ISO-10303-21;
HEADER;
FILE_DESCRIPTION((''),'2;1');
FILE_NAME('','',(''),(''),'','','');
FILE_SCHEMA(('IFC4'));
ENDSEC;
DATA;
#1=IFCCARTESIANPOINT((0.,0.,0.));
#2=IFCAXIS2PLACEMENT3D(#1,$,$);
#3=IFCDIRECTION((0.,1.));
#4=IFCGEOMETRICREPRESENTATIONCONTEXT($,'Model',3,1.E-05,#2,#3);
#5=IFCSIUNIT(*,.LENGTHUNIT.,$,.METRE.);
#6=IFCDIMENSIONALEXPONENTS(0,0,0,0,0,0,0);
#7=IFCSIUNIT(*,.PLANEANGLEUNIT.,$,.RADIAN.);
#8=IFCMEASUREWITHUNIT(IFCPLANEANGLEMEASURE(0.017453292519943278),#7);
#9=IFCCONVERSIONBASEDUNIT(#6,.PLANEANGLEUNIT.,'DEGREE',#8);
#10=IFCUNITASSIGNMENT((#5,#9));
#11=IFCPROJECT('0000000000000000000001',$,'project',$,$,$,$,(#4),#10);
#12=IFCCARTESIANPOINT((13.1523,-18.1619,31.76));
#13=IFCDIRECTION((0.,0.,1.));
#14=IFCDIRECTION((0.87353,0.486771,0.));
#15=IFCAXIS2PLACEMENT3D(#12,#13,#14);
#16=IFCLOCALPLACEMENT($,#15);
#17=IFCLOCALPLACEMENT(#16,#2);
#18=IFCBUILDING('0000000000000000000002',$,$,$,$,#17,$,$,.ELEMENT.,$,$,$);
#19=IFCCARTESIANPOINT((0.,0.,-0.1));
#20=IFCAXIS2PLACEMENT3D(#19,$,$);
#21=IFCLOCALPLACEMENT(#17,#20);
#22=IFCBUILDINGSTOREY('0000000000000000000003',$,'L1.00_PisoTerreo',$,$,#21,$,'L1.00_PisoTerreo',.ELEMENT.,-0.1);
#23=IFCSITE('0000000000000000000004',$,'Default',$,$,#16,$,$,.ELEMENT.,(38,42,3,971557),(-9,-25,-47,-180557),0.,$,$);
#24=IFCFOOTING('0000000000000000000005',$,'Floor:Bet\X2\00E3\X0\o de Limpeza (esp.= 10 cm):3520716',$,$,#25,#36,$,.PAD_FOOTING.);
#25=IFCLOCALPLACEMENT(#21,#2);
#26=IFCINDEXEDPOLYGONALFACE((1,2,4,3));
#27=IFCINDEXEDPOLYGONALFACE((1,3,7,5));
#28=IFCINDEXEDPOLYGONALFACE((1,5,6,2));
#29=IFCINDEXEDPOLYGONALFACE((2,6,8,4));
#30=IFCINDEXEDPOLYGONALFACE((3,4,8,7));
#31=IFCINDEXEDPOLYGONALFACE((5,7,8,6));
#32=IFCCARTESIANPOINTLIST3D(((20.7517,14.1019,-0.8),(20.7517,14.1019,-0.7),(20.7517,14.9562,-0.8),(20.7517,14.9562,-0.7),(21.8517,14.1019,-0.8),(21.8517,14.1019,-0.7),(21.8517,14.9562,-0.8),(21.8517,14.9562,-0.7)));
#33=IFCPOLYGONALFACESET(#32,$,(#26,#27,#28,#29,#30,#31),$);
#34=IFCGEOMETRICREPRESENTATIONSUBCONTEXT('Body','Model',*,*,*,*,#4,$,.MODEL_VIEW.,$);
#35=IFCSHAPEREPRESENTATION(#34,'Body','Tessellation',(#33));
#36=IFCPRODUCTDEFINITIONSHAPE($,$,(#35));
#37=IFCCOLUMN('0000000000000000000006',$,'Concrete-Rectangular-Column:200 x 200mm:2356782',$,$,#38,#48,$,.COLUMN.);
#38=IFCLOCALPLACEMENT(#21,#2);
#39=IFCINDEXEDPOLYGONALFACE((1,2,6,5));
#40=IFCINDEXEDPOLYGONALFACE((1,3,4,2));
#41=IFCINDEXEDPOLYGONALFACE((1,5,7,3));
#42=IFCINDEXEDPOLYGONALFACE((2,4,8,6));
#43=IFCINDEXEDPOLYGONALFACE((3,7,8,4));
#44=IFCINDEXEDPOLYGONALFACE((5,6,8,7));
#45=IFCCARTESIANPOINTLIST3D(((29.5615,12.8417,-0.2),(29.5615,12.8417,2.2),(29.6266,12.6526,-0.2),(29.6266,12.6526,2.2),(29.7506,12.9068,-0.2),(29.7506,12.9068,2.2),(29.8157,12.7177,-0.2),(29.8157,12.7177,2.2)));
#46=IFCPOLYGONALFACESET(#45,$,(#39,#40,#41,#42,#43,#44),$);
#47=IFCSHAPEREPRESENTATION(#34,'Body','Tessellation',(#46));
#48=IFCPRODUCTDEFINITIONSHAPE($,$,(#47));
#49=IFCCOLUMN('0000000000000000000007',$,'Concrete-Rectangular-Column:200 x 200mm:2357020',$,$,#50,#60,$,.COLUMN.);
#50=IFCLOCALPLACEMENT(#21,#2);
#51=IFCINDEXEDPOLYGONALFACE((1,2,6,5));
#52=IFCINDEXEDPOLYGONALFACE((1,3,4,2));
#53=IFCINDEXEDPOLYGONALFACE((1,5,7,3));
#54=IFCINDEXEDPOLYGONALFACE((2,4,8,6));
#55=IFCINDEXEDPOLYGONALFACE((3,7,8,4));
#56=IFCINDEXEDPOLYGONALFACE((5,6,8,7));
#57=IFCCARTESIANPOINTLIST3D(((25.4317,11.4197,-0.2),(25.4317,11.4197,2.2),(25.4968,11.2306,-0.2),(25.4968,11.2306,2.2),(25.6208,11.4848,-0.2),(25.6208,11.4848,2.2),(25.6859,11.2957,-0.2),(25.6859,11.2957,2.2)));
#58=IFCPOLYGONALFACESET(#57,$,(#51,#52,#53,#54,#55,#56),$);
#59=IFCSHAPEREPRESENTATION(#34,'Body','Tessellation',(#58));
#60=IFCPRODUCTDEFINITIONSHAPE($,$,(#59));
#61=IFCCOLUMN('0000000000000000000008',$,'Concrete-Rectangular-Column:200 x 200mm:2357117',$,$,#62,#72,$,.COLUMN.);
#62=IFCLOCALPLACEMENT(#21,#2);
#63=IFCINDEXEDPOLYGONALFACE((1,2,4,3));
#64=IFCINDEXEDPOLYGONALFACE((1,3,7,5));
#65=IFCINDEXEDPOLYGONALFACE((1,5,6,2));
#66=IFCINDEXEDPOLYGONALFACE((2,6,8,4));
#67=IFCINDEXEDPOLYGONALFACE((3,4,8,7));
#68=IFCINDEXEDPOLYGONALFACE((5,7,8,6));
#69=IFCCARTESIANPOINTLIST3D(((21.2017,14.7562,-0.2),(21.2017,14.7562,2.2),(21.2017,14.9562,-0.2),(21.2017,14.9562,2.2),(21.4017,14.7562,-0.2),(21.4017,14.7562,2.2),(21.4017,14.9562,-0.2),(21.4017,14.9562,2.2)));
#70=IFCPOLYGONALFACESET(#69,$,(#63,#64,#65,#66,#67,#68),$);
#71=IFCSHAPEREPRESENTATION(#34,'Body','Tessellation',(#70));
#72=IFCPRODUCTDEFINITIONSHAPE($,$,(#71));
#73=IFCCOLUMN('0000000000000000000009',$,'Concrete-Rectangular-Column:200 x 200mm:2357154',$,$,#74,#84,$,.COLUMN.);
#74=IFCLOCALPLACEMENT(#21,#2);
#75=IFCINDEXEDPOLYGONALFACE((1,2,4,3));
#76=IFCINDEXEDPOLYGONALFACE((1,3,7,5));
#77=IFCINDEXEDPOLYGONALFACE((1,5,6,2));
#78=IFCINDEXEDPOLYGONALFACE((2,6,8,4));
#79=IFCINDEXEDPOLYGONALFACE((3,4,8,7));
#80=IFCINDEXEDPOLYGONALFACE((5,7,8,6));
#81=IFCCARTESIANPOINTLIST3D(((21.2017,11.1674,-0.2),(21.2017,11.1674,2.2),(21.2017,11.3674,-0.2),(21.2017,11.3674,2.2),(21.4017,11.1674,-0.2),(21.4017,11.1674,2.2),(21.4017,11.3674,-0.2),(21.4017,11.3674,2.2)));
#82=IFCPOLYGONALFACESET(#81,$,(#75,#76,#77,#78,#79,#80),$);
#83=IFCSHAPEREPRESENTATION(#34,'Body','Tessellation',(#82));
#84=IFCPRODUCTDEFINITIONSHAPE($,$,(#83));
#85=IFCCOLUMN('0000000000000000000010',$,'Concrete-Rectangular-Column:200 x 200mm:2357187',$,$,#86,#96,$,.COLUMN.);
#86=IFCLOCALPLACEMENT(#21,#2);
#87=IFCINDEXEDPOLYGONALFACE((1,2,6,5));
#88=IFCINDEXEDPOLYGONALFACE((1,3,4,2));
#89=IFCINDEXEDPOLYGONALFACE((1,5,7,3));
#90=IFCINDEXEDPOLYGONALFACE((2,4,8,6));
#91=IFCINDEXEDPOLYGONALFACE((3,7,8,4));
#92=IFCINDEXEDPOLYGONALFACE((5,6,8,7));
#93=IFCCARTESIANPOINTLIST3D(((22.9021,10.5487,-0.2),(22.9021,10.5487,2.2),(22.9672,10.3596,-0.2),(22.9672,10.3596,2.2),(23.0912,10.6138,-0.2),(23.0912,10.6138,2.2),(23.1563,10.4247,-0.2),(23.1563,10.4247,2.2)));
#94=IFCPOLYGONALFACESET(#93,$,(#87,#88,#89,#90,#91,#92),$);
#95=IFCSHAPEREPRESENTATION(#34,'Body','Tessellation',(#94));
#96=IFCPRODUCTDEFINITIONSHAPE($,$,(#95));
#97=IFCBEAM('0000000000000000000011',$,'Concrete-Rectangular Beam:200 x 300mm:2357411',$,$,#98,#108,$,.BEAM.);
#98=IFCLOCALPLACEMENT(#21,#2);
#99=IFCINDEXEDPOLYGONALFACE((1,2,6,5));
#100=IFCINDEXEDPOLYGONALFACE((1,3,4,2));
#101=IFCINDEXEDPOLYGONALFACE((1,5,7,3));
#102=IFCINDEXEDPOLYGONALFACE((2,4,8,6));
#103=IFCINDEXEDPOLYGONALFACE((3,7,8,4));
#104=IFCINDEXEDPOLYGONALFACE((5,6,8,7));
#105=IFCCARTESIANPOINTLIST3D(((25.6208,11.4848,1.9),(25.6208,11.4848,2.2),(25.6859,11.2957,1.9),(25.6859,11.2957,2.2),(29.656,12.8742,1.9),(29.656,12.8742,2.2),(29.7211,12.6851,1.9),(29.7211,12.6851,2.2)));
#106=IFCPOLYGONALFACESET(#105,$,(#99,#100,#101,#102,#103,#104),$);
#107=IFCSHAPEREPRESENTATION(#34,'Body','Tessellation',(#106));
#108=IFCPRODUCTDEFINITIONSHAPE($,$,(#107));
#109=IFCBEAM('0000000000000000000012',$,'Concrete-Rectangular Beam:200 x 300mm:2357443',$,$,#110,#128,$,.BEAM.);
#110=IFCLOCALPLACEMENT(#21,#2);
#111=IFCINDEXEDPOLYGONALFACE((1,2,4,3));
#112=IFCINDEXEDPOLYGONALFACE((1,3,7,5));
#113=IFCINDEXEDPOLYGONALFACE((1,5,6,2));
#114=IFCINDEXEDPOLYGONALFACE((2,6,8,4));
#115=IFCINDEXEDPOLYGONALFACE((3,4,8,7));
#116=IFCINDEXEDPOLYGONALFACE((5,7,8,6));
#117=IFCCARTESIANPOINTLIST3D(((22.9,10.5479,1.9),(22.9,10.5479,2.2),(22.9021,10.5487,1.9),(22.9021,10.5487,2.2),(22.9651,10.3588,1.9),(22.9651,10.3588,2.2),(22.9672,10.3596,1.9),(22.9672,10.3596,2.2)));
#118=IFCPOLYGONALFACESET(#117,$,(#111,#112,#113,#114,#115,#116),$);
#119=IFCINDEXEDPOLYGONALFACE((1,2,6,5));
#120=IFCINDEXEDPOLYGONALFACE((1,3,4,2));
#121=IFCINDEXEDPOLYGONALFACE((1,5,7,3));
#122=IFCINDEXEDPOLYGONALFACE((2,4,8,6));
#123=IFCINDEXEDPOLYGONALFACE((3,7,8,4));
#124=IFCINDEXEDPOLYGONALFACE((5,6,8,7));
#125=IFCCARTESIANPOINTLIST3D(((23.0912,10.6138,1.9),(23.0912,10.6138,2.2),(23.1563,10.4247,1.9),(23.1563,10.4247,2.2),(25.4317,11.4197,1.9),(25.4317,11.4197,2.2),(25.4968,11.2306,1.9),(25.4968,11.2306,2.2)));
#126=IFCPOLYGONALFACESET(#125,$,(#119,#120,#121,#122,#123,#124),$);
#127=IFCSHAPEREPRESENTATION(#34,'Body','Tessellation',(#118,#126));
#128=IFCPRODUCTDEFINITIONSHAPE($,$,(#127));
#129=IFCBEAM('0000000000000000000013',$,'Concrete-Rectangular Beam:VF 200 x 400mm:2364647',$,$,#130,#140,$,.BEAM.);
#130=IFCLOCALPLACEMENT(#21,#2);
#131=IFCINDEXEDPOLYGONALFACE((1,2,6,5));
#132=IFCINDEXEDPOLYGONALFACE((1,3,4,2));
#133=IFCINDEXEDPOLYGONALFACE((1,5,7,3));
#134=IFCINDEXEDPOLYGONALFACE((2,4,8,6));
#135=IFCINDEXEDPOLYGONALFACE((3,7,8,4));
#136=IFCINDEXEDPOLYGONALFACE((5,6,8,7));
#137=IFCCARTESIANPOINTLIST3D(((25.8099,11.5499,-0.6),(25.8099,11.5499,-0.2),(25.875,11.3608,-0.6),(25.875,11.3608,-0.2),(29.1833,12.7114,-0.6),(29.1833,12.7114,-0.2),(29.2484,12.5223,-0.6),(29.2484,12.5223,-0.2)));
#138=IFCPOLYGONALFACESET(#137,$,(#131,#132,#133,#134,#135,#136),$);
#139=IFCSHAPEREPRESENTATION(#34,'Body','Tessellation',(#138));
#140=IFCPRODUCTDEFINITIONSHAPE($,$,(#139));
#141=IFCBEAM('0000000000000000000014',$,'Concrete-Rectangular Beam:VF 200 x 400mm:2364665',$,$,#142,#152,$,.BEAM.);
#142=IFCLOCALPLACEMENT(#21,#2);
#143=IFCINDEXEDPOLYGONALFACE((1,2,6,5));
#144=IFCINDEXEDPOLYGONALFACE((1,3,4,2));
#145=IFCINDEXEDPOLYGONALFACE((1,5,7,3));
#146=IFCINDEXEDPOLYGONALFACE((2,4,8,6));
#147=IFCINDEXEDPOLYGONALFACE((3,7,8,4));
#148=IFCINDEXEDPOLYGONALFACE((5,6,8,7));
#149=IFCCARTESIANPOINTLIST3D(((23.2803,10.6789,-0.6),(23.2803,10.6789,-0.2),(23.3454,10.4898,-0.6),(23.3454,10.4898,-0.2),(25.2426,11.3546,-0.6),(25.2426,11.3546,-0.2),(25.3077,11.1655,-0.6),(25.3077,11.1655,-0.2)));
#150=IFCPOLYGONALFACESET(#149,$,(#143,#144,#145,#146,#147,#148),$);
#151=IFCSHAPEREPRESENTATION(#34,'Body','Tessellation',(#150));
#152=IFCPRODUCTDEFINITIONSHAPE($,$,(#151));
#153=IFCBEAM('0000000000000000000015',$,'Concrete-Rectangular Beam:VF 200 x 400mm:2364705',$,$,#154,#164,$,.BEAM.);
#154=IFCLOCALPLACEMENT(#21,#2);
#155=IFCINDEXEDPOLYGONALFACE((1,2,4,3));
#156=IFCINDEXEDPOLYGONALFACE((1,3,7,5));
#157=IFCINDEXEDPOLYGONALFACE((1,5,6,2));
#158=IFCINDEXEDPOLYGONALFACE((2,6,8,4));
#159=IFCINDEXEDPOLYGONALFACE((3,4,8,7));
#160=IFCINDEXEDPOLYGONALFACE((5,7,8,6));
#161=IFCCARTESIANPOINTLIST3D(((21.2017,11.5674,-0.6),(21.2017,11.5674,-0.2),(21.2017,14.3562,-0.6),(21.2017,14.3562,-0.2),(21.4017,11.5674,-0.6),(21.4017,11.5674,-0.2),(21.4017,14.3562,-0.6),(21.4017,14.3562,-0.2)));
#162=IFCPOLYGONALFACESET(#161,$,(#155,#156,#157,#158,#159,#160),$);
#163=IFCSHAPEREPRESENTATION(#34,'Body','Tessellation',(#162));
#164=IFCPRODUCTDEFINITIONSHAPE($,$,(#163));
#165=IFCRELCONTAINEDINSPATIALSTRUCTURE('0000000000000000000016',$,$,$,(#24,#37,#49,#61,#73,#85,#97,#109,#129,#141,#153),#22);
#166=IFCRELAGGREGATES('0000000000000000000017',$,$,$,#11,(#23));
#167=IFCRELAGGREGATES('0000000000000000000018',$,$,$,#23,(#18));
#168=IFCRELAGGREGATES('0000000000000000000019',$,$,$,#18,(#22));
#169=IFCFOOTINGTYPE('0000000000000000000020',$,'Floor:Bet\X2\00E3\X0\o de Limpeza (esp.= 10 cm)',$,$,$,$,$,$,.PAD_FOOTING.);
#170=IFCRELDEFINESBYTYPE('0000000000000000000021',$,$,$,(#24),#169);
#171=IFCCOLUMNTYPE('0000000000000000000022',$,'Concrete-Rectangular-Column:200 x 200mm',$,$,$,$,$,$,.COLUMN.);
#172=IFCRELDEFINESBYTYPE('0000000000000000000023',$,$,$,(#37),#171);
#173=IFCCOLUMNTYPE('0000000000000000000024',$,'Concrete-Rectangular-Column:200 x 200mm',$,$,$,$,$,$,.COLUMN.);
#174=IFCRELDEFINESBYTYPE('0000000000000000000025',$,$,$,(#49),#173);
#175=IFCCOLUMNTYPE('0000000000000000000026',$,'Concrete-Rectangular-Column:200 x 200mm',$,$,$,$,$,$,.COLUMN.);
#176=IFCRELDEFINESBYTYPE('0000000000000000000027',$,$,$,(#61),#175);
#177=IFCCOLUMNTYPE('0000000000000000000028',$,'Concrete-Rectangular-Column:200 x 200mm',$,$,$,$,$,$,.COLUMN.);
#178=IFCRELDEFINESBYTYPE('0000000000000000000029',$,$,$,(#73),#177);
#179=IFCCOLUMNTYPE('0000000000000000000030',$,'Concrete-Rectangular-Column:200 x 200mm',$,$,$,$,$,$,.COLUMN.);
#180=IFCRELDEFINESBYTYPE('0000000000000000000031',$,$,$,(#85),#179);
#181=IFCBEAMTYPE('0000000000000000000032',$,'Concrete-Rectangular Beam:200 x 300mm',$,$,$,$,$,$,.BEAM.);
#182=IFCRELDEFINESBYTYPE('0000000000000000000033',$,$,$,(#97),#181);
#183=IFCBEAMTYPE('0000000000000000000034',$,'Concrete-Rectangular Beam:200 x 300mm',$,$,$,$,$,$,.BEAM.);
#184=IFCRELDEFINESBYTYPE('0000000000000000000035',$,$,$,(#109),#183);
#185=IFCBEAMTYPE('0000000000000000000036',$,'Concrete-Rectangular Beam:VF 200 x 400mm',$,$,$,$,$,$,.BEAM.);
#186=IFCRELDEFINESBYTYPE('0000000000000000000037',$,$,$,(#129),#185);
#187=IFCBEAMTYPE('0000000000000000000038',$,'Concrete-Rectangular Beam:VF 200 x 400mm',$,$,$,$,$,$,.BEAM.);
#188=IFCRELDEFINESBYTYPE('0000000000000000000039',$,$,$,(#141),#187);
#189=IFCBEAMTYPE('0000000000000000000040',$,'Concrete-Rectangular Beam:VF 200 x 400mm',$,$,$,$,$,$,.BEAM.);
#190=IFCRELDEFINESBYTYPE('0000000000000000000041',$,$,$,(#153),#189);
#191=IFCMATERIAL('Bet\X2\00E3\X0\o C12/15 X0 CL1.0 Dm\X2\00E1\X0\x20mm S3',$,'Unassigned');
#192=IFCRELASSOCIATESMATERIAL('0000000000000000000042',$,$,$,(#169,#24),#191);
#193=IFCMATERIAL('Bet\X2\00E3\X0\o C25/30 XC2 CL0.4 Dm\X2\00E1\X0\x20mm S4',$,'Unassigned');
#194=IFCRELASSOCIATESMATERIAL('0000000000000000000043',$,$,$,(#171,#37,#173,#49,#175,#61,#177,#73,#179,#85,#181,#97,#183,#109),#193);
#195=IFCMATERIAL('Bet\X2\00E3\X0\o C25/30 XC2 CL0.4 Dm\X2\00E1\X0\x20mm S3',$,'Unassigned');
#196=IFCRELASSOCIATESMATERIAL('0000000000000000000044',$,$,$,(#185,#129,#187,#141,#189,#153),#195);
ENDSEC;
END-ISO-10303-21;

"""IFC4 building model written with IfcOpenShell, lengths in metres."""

from ifc_helpers import new_model, entity, si_unit, converted_unit, direction, frame, origin, place, context, subcontext, project, spatial, indexed_curve, outline, extrude, source, transform, mapped, material, type_object, type_shapes, element, save


model = new_model("IFC4")

# Units and contexts
model_context = context("Model", 3, precision=1e-05, world=origin(), true_north=direction((0.0, 1.0)))
body_context = subcontext(model_context, "Body", "Model", "MODEL_VIEW")
ifc_project = project(units=[si_unit("LENGTHUNIT", "METRE"), converted_unit("PLANEANGLEUNIT", "DEGREE", entity("IfcPlaneAngleMeasure", 0.017453292519943278), si_unit("PLANEANGLEUNIT", "RADIAN"), dimensions=[0, 0, 0, 0, 0, 0, 0])], contexts=[model_context])

# Site, building, storey
site_placement = place(None, frame((13.1523, -18.1619, 31.76), z_axis=(0.0, 0.0, 1.0), x_axis=(0.87353, 0.486771, 0.0)))
site = spatial("IfcSite", under=ifc_project, at=site_placement, Name="Default", CompositionType="ELEMENT", RefLatitude=(38, 42, 3, 971557), RefLongitude=(-9, -25, -47, -180557), RefElevation=0.0)
building_placement = place(site_placement, origin())
building = spatial("IfcBuilding", under=site, at=building_placement, CompositionType="ELEMENT")
storey_placement = place(building_placement, frame((0.0, 0.0, -0.1)))
storey = spatial("IfcBuildingStorey", under=building, at=storey_placement, Name="L1.00_PisoTerreo", LongName="L1.00_PisoTerreo", CompositionType="ELEMENT", Elevation=-0.1)

# Footing
ifc_material_1 = material(Name="Betão C12/15 X0 CL1.0 Dmáx20mm S3", Category="Unassigned")
footing_type = type_object("IfcFootingType", Name="Floor:Betão de Limpeza (esp.= 10 cm)", PredefinedType="PAD_FOOTING", material=ifc_material_1)
footing_1_placement = place(storey_placement, origin())
element("IfcFooting", 1, at=footing_1_placement, inside=storey, type_object=footing_type, material=ifc_material_1, Name="Floor:Betão de Limpeza (esp.= 10 cm):3520716", PredefinedType="PAD_FOOTING", context=body_context, shape_type="SweptSolid", body=[
    extrude(outline(indexed_curve([(-0.4272, -0.55), (0.4272, -0.55), (0.4272, 0.55), (-0.4272, 0.55), (-0.4272, -0.55)], self_intersect=False)), frame((21.3017, 14.5291, -0.7), z_axis=(0.0, 0.0, -1.0), x_axis=(0.0, 1.0, 0.0)), (0.0, 0.0, 1.0), 0.1),
])

# Columns
ifc_material_2 = material(Name="Betão C25/30 XC2 CL0.4 Dmáx20mm S4", Category="Unassigned")
column_type_1 = type_object("IfcColumnType", Name="Concrete-Rectangular-Column:200 x 200mm", PredefinedType="COLUMN", material=ifc_material_2)
shared_shape_1 = source(origin(), body_context, "Body", "SweptSolid", [
    extrude(outline(indexed_curve([(-0.1, -0.1), (0.1, -0.1), (0.1, 0.1), (-0.1, 0.1), (-0.1, -0.1)], self_intersect=False)), frame((29.6886, 12.7797, -0.3), z_axis=(0.0, 0.0, 1.0), x_axis=(-0.945519, -0.325568, 0.0)), (0.0, 0.0, 1.0), 2.4),
])
type_shapes(column_type_1, [shared_shape_1])
column_1_placement = place(storey_placement, frame((0.0, 0.0, 0.1)))
element("IfcColumn", 2, at=column_1_placement, inside=storey, type_object=column_type_1, material=ifc_material_2, Name="Concrete-Rectangular-Column:200 x 200mm:2356782", PredefinedType="COLUMN", context=body_context, shape_type="MappedRepresentation", body=[
    mapped(shared_shape_1, transform((0.0, 0.0, 0.0), scale=1.0)),
])
column_type_2 = type_object("IfcColumnType", Name="Concrete-Rectangular-Column:200 x 200mm", PredefinedType="COLUMN", material=ifc_material_2)
shared_shape_2 = source(origin(), body_context, "Body", "SweptSolid", [
    extrude(outline(indexed_curve([(-0.1, -0.1), (0.1, -0.1), (0.1, 0.1), (-0.1, 0.1), (-0.1, -0.1)], self_intersect=False)), frame((25.5588, 11.3577, -0.3), z_axis=(0.0, 0.0, 1.0), x_axis=(-0.945519, -0.325568, 0.0)), (0.0, 0.0, 1.0), 2.4),
])
type_shapes(column_type_2, [shared_shape_2])
column_2_placement = place(storey_placement, frame((0.0, 0.0, 0.1)))
element("IfcColumn", 3, at=column_2_placement, inside=storey, type_object=column_type_2, material=ifc_material_2, Name="Concrete-Rectangular-Column:200 x 200mm:2357020", PredefinedType="COLUMN", context=body_context, shape_type="MappedRepresentation", body=[
    mapped(shared_shape_2, transform((0.0, 0.0, 0.0), scale=1.0)),
])
column_type_3 = type_object("IfcColumnType", Name="Concrete-Rectangular-Column:200 x 200mm", PredefinedType="COLUMN", material=ifc_material_2)
shared_shape_3 = source(origin(), body_context, "Body", "SweptSolid", [
    extrude(outline(indexed_curve([(-0.1, -0.1), (0.1, -0.1), (0.1, 0.1), (-0.1, 0.1), (-0.1, -0.1)], self_intersect=False)), frame((21.3017, 14.8562, -0.3), z_axis=(0.0, 0.0, 1.0), x_axis=(-1.0, 0.0, 0.0)), (0.0, 0.0, 1.0), 2.4),
])
type_shapes(column_type_3, [shared_shape_3])
column_3_placement = place(storey_placement, frame((0.0, 0.0, 0.1)))
element("IfcColumn", 4, at=column_3_placement, inside=storey, type_object=column_type_3, material=ifc_material_2, Name="Concrete-Rectangular-Column:200 x 200mm:2357117", PredefinedType="COLUMN", context=body_context, shape_type="MappedRepresentation", body=[
    mapped(shared_shape_3, transform((0.0, 0.0, 0.0), scale=1.0)),
])
column_type_4 = type_object("IfcColumnType", Name="Concrete-Rectangular-Column:200 x 200mm", PredefinedType="COLUMN", material=ifc_material_2)
shared_shape_4 = source(origin(), body_context, "Body", "SweptSolid", [
    extrude(outline(indexed_curve([(-0.1, -0.1), (0.1, -0.1), (0.1, 0.1), (-0.1, 0.1), (-0.1, -0.1)], self_intersect=False)), frame((21.3017, 11.2674, -0.3), z_axis=(0.0, 0.0, 1.0), x_axis=(-1.0, 0.0, 0.0)), (0.0, 0.0, 1.0), 2.4),
])
type_shapes(column_type_4, [shared_shape_4])
column_4_placement = place(storey_placement, frame((0.0, 0.0, 0.1)))
element("IfcColumn", 5, at=column_4_placement, inside=storey, type_object=column_type_4, material=ifc_material_2, Name="Concrete-Rectangular-Column:200 x 200mm:2357154", PredefinedType="COLUMN", context=body_context, shape_type="MappedRepresentation", body=[
    mapped(shared_shape_4, transform((0.0, 0.0, 0.0), scale=1.0)),
])
column_type_5 = type_object("IfcColumnType", Name="Concrete-Rectangular-Column:200 x 200mm", PredefinedType="COLUMN", material=ifc_material_2)
shared_shape_5 = source(origin(), body_context, "Body", "SweptSolid", [
    extrude(outline(indexed_curve([(-0.1, -0.1), (0.1, -0.1), (0.1, 0.1), (-0.1, 0.1), (-0.1, -0.1)], self_intersect=False)), frame((23.0292, 10.4867, -0.3), z_axis=(0.0, 0.0, 1.0), x_axis=(-0.945519, -0.325568, 0.0)), (0.0, 0.0, 1.0), 2.4),
])
type_shapes(column_type_5, [shared_shape_5])
column_5_placement = place(storey_placement, frame((0.0, 0.0, 0.1)))
element("IfcColumn", 6, at=column_5_placement, inside=storey, type_object=column_type_5, material=ifc_material_2, Name="Concrete-Rectangular-Column:200 x 200mm:2357187", PredefinedType="COLUMN", context=body_context, shape_type="MappedRepresentation", body=[
    mapped(shared_shape_5, transform((0.0, 0.0, 0.0), scale=1.0)),
])

# Beams
beam_type_1 = type_object("IfcBeamType", Name="Concrete-Rectangular Beam:200 x 300mm", PredefinedType="BEAM", material=ifc_material_2)
shared_shape_6 = source(origin(), body_context, "Body", "SweptSolid", [
    extrude(outline(indexed_curve([(-0.15, -0.1), (0.15, -0.1), (0.15, 0.1), (-0.15, 0.1), (-0.15, -0.1)], self_intersect=False)), frame((29.6886, 12.7797, 1.95), z_axis=(-0.945519, -0.325568, 0.0), x_axis=(0.0, 0.0, -1.0)), (0.0, 0.0, 1.0), 4.2677),
])
type_shapes(beam_type_1, [shared_shape_6])
beam_1_placement = place(storey_placement, frame((0.0, 0.0, 0.1)))
element("IfcBeam", 7, at=beam_1_placement, inside=storey, type_object=beam_type_1, material=ifc_material_2, Name="Concrete-Rectangular Beam:200 x 300mm:2357411", PredefinedType="BEAM", context=body_context, shape_type="MappedRepresentation", body=[
    mapped(shared_shape_6, transform((0.0, 0.0, 0.0), scale=1.0)),
])
beam_type_2 = type_object("IfcBeamType", Name="Concrete-Rectangular Beam:200 x 300mm", PredefinedType="BEAM", material=ifc_material_2)
shared_shape_7 = source(origin(), body_context, "Body", "SweptSolid", [
    extrude(outline(indexed_curve([(-0.15, -0.1), (0.15, -0.1), (0.15, 0.1), (-0.15, 0.1), (-0.15, -0.1)], self_intersect=False)), frame((22.9346, 10.4541, 1.95), z_axis=(-0.945519, -0.325568, 0.0), x_axis=(0.0, 0.0, -1.0)), (0.0, 0.0, 1.0), 0.0022),
    extrude(outline(indexed_curve([(-0.15, -0.1), (0.15, -0.1), (0.15, 0.1), (-0.15, 0.1), (-0.15, -0.1)], self_intersect=False)), frame((25.4643, 11.3251, 1.95), z_axis=(-0.945519, -0.325568, 0.0), x_axis=(0.0, 0.0, -1.0)), (0.0, 0.0, 1.0), 2.4754),
])
type_shapes(beam_type_2, [shared_shape_7])
beam_2_placement = place(storey_placement, frame((0.0, 0.0, 0.1)))
element("IfcBeam", 8, at=beam_2_placement, inside=storey, type_object=beam_type_2, material=ifc_material_2, Name="Concrete-Rectangular Beam:200 x 300mm:2357443", PredefinedType="BEAM", context=body_context, shape_type="MappedRepresentation", body=[
    mapped(shared_shape_7, transform((0.0, 0.0, 0.0), scale=1.0)),
])
ifc_material_3 = material(Name="Betão C25/30 XC2 CL0.4 Dmáx20mm S3", Category="Unassigned")
beam_type_3 = type_object("IfcBeamType", Name="Concrete-Rectangular Beam:VF 200 x 400mm", PredefinedType="BEAM", material=ifc_material_3)
shared_shape_8 = source(origin(), body_context, "Body", "SweptSolid", [
    extrude(outline(indexed_curve([(-0.2, -0.1), (0.2, -0.1), (0.2, 0.1), (-0.2, 0.1), (-0.2, -0.1)], self_intersect=False)), frame((29.2158, 12.6169, -0.5), z_axis=(-0.945519, -0.325568, 0.0), x_axis=(0.0, 0.0, -1.0)), (0.0, 0.0, 1.0), 3.5677),
])
type_shapes(beam_type_3, [shared_shape_8])
beam_3_placement = place(storey_placement, frame((0.0, 0.0, 0.1)))
element("IfcBeam", 9, at=beam_3_placement, inside=storey, type_object=beam_type_3, material=ifc_material_3, Name="Concrete-Rectangular Beam:VF 200 x 400mm:2364647", PredefinedType="BEAM", context=body_context, shape_type="MappedRepresentation", body=[
    mapped(shared_shape_8, transform((0.0, 0.0, 0.0), scale=1.0)),
])
beam_type_4 = type_object("IfcBeamType", Name="Concrete-Rectangular Beam:VF 200 x 400mm", PredefinedType="BEAM", material=ifc_material_3)
shared_shape_9 = source(origin(), body_context, "Body", "SweptSolid", [
    extrude(outline(indexed_curve([(-0.2, -0.1), (0.2, -0.1), (0.2, 0.1), (-0.2, 0.1), (-0.2, -0.1)], self_intersect=False)), frame((25.2752, 11.26, -0.5), z_axis=(-0.945519, -0.325568, 0.0), x_axis=(0.0, 0.0, -1.0)), (0.0, 0.0, 1.0), 2.0754),
])
type_shapes(beam_type_4, [shared_shape_9])
beam_4_placement = place(storey_placement, frame((0.0, 0.0, 0.1)))
element("IfcBeam", 10, at=beam_4_placement, inside=storey, type_object=beam_type_4, material=ifc_material_3, Name="Concrete-Rectangular Beam:VF 200 x 400mm:2364665", PredefinedType="BEAM", context=body_context, shape_type="MappedRepresentation", body=[
    mapped(shared_shape_9, transform((0.0, 0.0, 0.0), scale=1.0)),
])
beam_type_5 = type_object("IfcBeamType", Name="Concrete-Rectangular Beam:VF 200 x 400mm", PredefinedType="BEAM", material=ifc_material_3)
shared_shape_10 = source(origin(), body_context, "Body", "SweptSolid", [
    extrude(outline(indexed_curve([(-0.1, -0.2), (0.1, -0.2), (0.1, 0.2), (-0.1, 0.2), (-0.1, -0.2)], self_intersect=False)), frame((21.3017, 11.5674, -0.5), z_axis=(0.0, 1.0, 0.0), x_axis=(-1.0, 0.0, 0.0)), (0.0, 0.0, 1.0), 2.7888),
])
type_shapes(beam_type_5, [shared_shape_10])
beam_5_placement = place(storey_placement, frame((0.0, 0.0, 0.1)))
element("IfcBeam", 11, at=beam_5_placement, inside=storey, type_object=beam_type_5, material=ifc_material_3, Name="Concrete-Rectangular Beam:VF 200 x 400mm:2364705", PredefinedType="BEAM", context=body_context, shape_type="MappedRepresentation", body=[
    mapped(shared_shape_10, transform((0.0, 0.0, 0.0), scale=1.0)),
])

save(model, "model.ifc")
